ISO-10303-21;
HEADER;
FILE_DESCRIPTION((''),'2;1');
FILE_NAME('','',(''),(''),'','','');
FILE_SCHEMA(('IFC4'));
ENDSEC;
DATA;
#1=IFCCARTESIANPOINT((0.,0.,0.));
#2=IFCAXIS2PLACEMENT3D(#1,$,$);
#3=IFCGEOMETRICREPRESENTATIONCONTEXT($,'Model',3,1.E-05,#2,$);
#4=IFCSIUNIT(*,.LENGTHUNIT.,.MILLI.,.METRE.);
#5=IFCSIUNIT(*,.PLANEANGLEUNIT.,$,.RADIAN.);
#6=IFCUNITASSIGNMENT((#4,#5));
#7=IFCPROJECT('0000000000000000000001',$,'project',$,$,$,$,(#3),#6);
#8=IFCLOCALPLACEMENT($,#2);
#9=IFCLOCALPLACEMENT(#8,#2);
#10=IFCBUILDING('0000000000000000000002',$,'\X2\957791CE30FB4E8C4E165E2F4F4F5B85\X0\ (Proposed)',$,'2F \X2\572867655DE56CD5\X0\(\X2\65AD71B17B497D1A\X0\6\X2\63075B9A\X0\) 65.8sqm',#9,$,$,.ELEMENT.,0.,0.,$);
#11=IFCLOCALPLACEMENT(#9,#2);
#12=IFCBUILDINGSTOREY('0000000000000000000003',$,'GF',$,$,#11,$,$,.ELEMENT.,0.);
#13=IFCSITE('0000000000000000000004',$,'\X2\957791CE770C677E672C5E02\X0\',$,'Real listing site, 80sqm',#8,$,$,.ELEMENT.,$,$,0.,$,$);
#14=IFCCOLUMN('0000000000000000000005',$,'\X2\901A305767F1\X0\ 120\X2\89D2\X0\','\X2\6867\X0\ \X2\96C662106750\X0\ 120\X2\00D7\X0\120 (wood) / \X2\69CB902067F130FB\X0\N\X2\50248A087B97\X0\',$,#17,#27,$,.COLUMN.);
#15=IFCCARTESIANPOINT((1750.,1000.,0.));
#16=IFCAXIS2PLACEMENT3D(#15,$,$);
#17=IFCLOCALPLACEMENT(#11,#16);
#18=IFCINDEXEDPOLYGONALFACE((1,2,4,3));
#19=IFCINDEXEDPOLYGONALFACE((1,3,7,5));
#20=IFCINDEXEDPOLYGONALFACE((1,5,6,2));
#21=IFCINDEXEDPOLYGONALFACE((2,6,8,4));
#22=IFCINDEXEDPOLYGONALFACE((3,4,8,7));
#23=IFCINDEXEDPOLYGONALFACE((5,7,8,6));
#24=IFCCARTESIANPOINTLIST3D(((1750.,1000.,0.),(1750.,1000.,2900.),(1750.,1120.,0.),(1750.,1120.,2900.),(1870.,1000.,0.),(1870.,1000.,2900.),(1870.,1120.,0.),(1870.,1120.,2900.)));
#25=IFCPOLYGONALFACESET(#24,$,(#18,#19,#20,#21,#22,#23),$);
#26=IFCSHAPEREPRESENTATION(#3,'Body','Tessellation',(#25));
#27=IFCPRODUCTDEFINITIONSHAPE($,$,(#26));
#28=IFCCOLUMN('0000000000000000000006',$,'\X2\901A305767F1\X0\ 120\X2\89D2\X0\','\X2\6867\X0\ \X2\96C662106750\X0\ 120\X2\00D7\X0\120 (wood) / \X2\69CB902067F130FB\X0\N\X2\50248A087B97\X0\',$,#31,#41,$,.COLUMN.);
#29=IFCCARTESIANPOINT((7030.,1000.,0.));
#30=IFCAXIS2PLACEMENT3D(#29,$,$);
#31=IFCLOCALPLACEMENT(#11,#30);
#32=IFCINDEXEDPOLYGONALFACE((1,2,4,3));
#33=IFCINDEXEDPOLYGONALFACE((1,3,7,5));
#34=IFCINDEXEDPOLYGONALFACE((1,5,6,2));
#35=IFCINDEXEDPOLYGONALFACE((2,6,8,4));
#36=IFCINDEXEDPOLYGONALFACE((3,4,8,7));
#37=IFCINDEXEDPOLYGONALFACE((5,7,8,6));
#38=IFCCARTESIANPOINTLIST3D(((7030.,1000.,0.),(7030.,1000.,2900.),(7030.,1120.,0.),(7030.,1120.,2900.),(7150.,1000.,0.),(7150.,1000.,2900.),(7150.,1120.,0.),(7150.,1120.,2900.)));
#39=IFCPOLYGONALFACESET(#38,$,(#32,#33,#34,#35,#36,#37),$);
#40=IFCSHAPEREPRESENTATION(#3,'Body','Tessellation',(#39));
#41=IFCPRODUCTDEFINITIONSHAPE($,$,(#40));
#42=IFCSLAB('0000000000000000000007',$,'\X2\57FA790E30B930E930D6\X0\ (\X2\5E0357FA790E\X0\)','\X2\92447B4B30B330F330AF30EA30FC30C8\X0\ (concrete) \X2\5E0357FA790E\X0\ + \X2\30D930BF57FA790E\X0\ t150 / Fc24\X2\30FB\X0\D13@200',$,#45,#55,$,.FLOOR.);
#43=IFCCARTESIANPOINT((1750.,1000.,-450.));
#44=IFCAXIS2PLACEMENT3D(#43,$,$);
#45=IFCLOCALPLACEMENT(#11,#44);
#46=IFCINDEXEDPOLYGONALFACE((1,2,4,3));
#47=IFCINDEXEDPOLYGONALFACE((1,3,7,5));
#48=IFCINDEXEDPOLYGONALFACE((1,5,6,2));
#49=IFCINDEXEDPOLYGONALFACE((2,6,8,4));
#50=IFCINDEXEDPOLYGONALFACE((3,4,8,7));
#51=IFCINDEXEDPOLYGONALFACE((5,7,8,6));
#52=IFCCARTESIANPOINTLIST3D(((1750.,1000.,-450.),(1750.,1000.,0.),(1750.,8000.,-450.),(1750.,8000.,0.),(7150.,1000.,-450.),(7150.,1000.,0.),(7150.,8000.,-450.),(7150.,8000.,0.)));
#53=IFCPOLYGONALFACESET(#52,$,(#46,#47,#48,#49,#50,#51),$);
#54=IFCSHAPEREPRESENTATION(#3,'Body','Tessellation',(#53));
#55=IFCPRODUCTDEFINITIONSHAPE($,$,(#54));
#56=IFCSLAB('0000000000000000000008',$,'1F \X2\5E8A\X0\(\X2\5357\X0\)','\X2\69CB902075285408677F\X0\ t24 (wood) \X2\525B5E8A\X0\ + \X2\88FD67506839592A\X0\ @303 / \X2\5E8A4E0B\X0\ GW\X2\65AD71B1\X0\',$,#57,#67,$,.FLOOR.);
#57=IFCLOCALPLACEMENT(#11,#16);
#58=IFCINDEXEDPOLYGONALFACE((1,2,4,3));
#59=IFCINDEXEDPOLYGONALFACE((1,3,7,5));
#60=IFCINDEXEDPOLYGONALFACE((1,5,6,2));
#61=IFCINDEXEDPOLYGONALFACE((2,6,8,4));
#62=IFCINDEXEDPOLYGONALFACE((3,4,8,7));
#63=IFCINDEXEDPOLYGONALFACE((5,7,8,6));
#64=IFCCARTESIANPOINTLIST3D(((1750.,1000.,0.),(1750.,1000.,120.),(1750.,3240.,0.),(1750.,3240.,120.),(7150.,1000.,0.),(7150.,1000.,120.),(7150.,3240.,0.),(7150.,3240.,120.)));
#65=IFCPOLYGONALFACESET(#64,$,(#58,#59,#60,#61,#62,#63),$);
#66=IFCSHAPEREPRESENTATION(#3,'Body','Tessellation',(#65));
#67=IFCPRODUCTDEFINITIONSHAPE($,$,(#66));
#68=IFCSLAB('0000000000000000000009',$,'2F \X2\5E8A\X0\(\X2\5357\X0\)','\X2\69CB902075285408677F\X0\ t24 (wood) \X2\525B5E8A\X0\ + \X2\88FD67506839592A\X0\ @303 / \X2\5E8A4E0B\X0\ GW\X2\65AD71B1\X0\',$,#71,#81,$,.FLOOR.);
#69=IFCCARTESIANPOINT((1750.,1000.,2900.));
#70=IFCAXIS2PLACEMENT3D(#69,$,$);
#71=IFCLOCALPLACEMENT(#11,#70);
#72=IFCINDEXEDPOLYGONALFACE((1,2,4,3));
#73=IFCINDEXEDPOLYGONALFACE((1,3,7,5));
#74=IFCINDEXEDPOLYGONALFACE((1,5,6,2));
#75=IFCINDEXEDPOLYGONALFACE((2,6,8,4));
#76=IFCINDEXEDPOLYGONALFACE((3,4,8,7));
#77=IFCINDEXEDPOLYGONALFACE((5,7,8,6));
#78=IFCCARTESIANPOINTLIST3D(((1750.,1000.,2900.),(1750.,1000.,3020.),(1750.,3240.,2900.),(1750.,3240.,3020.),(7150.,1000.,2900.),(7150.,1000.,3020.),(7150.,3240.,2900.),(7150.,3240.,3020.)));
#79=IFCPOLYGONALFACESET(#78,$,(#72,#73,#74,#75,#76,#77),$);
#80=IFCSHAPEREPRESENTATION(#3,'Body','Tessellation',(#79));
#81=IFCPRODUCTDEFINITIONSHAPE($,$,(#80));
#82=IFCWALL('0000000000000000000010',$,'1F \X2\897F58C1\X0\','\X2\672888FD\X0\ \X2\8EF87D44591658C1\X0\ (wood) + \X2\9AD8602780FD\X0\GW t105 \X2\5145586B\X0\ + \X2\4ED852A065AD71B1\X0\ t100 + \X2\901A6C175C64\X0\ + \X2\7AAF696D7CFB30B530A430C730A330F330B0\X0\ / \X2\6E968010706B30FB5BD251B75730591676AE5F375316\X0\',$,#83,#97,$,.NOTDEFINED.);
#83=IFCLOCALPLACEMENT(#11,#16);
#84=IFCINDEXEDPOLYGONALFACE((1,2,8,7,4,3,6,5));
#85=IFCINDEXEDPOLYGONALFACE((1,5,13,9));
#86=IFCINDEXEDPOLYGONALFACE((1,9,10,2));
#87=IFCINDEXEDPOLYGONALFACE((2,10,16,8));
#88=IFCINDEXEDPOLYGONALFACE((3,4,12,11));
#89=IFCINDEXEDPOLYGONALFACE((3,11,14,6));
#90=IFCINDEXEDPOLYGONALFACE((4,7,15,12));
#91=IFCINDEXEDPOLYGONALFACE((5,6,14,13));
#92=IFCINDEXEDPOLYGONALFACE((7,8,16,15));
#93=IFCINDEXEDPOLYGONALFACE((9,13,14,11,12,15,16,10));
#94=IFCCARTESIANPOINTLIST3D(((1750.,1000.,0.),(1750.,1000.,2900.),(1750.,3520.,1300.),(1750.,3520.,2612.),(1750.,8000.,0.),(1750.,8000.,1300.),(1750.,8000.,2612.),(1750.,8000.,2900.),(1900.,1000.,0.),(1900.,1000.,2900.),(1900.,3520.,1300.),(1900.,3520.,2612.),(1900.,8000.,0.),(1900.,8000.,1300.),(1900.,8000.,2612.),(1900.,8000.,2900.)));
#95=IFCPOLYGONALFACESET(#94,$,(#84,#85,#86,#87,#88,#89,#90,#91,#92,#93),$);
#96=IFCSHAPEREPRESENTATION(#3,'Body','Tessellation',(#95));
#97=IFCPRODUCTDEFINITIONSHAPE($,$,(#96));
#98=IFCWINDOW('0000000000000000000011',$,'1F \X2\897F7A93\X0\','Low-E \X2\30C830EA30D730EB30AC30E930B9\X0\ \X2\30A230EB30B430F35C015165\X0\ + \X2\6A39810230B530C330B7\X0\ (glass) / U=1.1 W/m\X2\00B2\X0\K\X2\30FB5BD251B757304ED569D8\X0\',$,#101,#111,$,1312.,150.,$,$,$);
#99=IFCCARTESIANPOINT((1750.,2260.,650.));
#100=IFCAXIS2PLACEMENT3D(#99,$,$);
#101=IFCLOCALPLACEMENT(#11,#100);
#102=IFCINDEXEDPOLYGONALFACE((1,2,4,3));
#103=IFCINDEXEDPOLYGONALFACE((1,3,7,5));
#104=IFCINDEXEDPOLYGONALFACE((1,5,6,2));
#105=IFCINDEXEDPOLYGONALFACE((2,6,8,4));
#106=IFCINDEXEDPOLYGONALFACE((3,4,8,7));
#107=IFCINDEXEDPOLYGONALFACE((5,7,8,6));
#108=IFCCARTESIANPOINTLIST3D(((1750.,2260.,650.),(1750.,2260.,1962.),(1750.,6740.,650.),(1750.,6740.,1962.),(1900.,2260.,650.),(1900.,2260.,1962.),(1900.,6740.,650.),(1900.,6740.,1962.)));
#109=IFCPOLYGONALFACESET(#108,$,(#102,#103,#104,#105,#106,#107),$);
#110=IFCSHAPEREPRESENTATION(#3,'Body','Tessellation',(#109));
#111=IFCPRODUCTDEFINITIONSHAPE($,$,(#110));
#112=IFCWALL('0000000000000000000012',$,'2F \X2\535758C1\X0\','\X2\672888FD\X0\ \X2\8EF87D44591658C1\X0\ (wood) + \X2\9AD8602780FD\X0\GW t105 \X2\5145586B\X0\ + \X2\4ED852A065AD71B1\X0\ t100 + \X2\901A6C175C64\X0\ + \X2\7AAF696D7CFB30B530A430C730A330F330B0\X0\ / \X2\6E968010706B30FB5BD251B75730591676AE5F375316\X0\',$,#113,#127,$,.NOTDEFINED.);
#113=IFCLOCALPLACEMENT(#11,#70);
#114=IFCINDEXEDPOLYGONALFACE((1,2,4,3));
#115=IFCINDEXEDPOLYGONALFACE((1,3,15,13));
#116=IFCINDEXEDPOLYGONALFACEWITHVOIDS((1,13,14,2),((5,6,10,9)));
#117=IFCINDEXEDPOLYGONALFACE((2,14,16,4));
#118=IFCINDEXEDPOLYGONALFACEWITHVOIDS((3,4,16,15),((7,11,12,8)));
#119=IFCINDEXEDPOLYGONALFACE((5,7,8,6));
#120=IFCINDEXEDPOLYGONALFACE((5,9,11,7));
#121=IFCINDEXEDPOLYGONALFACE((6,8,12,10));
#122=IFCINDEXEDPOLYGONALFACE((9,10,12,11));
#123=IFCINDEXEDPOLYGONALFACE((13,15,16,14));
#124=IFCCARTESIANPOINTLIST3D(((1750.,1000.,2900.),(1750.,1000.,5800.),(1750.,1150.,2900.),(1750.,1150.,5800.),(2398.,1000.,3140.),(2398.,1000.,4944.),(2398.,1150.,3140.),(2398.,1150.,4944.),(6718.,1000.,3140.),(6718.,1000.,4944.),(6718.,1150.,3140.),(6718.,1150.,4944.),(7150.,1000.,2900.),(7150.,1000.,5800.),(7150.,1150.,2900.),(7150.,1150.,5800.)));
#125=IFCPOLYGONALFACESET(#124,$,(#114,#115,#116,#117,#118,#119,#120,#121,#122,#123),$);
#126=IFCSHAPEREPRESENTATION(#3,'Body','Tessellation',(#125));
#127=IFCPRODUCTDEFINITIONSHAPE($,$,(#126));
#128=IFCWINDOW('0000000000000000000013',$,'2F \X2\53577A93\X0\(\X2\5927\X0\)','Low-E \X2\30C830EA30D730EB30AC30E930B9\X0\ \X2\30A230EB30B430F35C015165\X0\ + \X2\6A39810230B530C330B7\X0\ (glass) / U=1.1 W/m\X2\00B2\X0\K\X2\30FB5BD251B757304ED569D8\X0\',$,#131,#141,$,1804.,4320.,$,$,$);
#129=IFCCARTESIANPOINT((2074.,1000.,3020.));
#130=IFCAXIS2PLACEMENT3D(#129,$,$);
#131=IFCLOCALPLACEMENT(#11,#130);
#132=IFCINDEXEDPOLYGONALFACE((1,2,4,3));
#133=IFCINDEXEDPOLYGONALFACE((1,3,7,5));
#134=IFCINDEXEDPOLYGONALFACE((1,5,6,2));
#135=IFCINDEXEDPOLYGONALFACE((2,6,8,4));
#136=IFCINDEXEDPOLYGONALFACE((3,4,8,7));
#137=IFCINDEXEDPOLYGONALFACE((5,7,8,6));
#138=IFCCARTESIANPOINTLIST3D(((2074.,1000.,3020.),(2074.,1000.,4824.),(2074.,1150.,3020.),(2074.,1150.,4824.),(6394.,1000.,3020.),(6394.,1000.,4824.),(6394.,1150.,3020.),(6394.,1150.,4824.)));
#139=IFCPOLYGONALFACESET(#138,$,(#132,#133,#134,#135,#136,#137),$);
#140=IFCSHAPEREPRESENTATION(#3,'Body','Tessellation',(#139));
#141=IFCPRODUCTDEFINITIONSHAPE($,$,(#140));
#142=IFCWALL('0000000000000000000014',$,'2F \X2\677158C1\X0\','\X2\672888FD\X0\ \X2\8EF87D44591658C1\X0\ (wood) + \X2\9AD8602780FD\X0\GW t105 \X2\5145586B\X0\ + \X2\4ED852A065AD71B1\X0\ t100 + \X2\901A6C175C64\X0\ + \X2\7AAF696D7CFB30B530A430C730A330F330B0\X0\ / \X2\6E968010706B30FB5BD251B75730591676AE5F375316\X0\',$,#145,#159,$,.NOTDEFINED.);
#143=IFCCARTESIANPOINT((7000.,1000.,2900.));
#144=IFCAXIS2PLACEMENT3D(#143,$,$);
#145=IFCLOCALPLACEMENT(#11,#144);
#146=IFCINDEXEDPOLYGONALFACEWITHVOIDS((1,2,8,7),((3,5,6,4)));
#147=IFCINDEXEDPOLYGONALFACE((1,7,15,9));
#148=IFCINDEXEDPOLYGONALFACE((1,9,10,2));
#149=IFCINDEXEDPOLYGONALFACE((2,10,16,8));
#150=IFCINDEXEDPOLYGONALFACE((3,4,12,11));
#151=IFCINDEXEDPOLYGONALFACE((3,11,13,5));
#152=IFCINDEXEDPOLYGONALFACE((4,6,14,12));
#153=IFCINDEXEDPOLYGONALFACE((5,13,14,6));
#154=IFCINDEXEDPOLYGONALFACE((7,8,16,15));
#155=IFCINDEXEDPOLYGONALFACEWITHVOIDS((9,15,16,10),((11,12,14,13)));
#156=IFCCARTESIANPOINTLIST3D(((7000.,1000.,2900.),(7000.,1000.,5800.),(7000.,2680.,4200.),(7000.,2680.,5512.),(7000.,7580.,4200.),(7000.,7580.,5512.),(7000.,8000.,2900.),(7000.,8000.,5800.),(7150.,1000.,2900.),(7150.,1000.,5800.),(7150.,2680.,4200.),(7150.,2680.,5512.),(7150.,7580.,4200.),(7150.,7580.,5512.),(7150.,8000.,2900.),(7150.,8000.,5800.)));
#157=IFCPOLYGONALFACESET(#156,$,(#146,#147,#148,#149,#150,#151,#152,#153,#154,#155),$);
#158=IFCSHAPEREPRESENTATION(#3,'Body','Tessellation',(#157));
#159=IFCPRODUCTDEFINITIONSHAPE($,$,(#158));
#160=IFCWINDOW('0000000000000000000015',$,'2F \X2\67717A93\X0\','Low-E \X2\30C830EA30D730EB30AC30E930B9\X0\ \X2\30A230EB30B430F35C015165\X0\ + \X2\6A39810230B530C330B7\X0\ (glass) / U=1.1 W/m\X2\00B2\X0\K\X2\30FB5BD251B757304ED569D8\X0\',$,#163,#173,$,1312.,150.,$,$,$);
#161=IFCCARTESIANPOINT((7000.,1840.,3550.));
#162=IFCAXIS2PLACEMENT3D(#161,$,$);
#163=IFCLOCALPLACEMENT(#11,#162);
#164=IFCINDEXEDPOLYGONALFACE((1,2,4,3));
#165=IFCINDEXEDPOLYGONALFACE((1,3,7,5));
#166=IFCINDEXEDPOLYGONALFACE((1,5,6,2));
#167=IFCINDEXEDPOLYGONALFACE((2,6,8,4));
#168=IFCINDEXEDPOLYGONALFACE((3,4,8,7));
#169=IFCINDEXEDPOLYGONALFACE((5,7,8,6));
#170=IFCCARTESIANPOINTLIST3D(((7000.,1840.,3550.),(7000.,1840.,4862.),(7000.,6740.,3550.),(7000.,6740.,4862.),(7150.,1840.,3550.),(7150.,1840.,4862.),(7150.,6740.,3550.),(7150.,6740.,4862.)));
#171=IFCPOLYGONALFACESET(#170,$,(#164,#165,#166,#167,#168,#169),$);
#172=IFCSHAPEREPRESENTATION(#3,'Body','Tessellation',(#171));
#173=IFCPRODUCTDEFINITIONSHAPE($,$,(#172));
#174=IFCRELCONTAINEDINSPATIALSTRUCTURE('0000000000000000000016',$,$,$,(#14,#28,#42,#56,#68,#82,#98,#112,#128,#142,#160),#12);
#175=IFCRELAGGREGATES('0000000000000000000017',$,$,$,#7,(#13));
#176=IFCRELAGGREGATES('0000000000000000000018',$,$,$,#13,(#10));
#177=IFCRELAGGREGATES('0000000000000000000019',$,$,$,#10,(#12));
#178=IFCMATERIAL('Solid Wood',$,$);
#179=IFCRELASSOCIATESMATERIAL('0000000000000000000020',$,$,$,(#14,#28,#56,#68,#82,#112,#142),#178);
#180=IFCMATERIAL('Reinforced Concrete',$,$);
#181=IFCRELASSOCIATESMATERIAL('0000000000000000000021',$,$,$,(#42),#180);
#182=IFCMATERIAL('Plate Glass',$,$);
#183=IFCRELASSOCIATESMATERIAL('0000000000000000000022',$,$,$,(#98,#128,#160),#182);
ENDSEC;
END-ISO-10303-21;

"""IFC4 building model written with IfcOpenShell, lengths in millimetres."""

from ifc_helpers import new_model, si_unit, frame, frame_2d, origin, place, context, project, spatial, rectangle, extrude, material, element, fill, save


model = new_model("IFC4")

# Units and contexts
model_context = context("Model", 3, precision=1e-05, world=origin())
ifc_project = project(units=[si_unit("LENGTHUNIT", "METRE", prefix="MILLI"), si_unit("PLANEANGLEUNIT", "RADIAN")], contexts=[model_context])

# Site, building, storey
site_placement = place(None, origin())
site = spatial("IfcSite", under=ifc_project, at=site_placement, Name="長野県松本市", ObjectType="Real listing site, 80sqm", CompositionType="ELEMENT", RefElevation=0.0)
building_placement = place(site_placement, origin())
building = spatial("IfcBuilding", under=site, at=building_placement, Name="長野・二世帯住宅 (Proposed)", ObjectType="2F 在来工法(断熱等級6指定) 65.8sqm", CompositionType="ELEMENT", ElevationOfRefHeight=0.0, ElevationOfTerrain=0.0)
storey_placement = place(building_placement, origin())
storey = spatial("IfcBuildingStorey", under=building, at=storey_placement, Name="GF", CompositionType="ELEMENT", Elevation=0.0)

# Columns
ifc_material_1 = material(Name="Solid Wood")
column_1_placement = place(storey_placement, frame((1750.0, 1000.0, 0.0)))
element("IfcColumn", 1, at=column_1_placement, inside=storey, material=ifc_material_1, Name="通し柱 120角", Description="桧 集成材 120×120 (wood) / 構造柱・N値計算", PredefinedType="COLUMN", context=model_context, shape_type="SweptSolid", body=[
    extrude(rectangle(XDim=120.0, YDim=120.0, at=frame_2d((60.0, 60.0))), frame((1750.0, 1000.0, 0.0)), (0.0, 0.0, 1.0), 2900.0),
])
column_2_placement = place(storey_placement, frame((7030.0, 1000.0, 0.0)))
element("IfcColumn", 2, at=column_2_placement, inside=storey, material=ifc_material_1, Name="通し柱 120角", Description="桧 集成材 120×120 (wood) / 構造柱・N値計算", PredefinedType="COLUMN", context=model_context, shape_type="SweptSolid", body=[
    extrude(rectangle(XDim=120.0, YDim=120.0, at=frame_2d((60.0, 60.0))), frame((7030.0, 1000.0, 0.0)), (0.0, 0.0, 1.0), 2900.0),
])

# Slabs
ifc_material_2 = material(Name="Reinforced Concrete")
slab_1_placement = place(storey_placement, frame((1750.0, 1000.0, -450.0)))
element("IfcSlab", 3, at=slab_1_placement, inside=storey, material=ifc_material_2, Name="基礎スラブ (布基礎)", Description="鉄筋コンクリート (concrete) 布基礎 + ベタ基礎 t150 / Fc24・D13@200", PredefinedType="FLOOR", context=model_context, shape_type="SweptSolid", body=[
    extrude(rectangle(XDim=5400.0, YDim=7000.0, at=frame_2d((2700.0, 3500.0))), frame((1750.0, 1000.0, -450.0)), (0.0, 0.0, 1.0), 450.0),
])
slab_2_placement = place(storey_placement, frame((1750.0, 1000.0, 0.0)))
element("IfcSlab", 4, at=slab_2_placement, inside=storey, material=ifc_material_1, Name="1F 床(南)", Description="構造用合板 t24 (wood) 剛床 + 製材根太 @303 / 床下 GW断熱", PredefinedType="FLOOR", context=model_context, shape_type="SweptSolid", body=[
    extrude(rectangle(XDim=5400.0, YDim=2240.0, at=frame_2d((2700.0, 1120.0))), frame((1750.0, 1000.0, 0.0)), (0.0, 0.0, 1.0), 120.0),
])
slab_3_placement = place(storey_placement, frame((1750.0, 1000.0, 2900.0)))
element("IfcSlab", 5, at=slab_3_placement, inside=storey, material=ifc_material_1, Name="2F 床(南)", Description="構造用合板 t24 (wood) 剛床 + 製材根太 @303 / 床下 GW断熱", PredefinedType="FLOOR", context=model_context, shape_type="SweptSolid", body=[
    extrude(rectangle(XDim=5400.0, YDim=2240.0, at=frame_2d((2700.0, 1120.0))), frame((1750.0, 1000.0, 2900.0)), (0.0, 0.0, 1.0), 120.0),
])

# Shared definitions
ifc_material_3 = material(Name="Plate Glass")

# Walls, openings, windows
wall_1_placement = place(storey_placement, frame((1750.0, 1000.0, 0.0)))
wall_1 = element("IfcWall", 6, at=wall_1_placement, inside=storey, material=ifc_material_1, Name="1F 西壁", Description="木製 軸組外壁 (wood) + 高性能GW t105 充填 + 付加断熱 t100 + 通気層 + 窯業系サイディング / 準耐火・寒冷地外皮強化", PredefinedType="NOTDEFINED", context=model_context, shape_type="SweptSolid", body=[
    extrude(rectangle(XDim=150.0, YDim=7000.0, at=frame_2d((75.0, 3500.0))), frame((1750.0, 1000.0, 0.0)), (0.0, 0.0, 1.0), 2900.0),
])
opening_1_placement = place(storey_placement, frame((1750.0, 2260.0, 650.0)))
opening_1 = element("IfcOpeningElement", 7, at=opening_1_placement, cuts=wall_1, PredefinedType="NOTDEFINED", context=model_context, shape_type="SweptSolid", body=[
    extrude(rectangle(XDim=150.0, YDim=4480.0, at=frame_2d((75.0, 2240.0))), frame((1750.0, 2260.0, 650.0)), (0.0, 0.0, 1.0), 1312.0),
])
window_1_placement = place(storey_placement, frame((1750.0, 2260.0, 650.0)))
window_1 = element("IfcWindow", 8, at=window_1_placement, inside=storey, material=ifc_material_3, Name="1F 西窓", Description="Low-E トリプルガラス アルゴン封入 + 樹脂サッシ (glass) / U=1.1 W/m²K・寒冷地仕様", OverallHeight=1312.0, OverallWidth=150.0, context=model_context, shape_type="SweptSolid", body=[
    extrude(rectangle(XDim=150.0, YDim=4480.0, at=frame_2d((75.0, 2240.0))), frame((1750.0, 2260.0, 650.0)), (0.0, 0.0, 1.0), 1312.0),
])
fill(opening_1, window_1)
wall_2_placement = place(storey_placement, frame((1750.0, 1000.0, 2900.0)))
wall_2 = element("IfcWall", 9, at=wall_2_placement, inside=storey, material=ifc_material_1, Name="2F 南壁", Description="木製 軸組外壁 (wood) + 高性能GW t105 充填 + 付加断熱 t100 + 通気層 + 窯業系サイディング / 準耐火・寒冷地外皮強化", PredefinedType="NOTDEFINED", context=model_context, shape_type="SweptSolid", body=[
    extrude(rectangle(XDim=5400.0, YDim=150.0, at=frame_2d((2700.0, 75.0))), frame((1750.0, 1000.0, 2900.0)), (0.0, 0.0, 1.0), 2900.0),
])
opening_2_placement = place(storey_placement, frame((2074.0, 1000.0, 3020.0)))
opening_2 = element("IfcOpeningElement", 10, at=opening_2_placement, cuts=wall_2, PredefinedType="NOTDEFINED", context=model_context, shape_type="SweptSolid", body=[
    extrude(rectangle(XDim=4320.0, YDim=150.0, at=frame_2d((2160.0, 75.0))), frame((2074.0, 1000.0, 3020.0)), (0.0, 0.0, 1.0), 1804.0),
])
window_2_placement = place(storey_placement, frame((2074.0, 1000.0, 3020.0)))
window_2 = element("IfcWindow", 11, at=window_2_placement, inside=storey, material=ifc_material_3, Name="2F 南窓(大)", Description="Low-E トリプルガラス アルゴン封入 + 樹脂サッシ (glass) / U=1.1 W/m²K・寒冷地仕様", OverallHeight=1804.0, OverallWidth=4320.0, context=model_context, shape_type="SweptSolid", body=[
    extrude(rectangle(XDim=4320.0, YDim=150.0, at=frame_2d((2160.0, 75.0))), frame((2074.0, 1000.0, 3020.0)), (0.0, 0.0, 1.0), 1804.0),
])
fill(opening_2, window_2)
wall_3_placement = place(storey_placement, frame((7000.0, 1000.0, 2900.0)))
wall_3 = element("IfcWall", 12, at=wall_3_placement, inside=storey, material=ifc_material_1, Name="2F 東壁", Description="木製 軸組外壁 (wood) + 高性能GW t105 充填 + 付加断熱 t100 + 通気層 + 窯業系サイディング / 準耐火・寒冷地外皮強化", PredefinedType="NOTDEFINED", context=model_context, shape_type="SweptSolid", body=[
    extrude(rectangle(XDim=150.0, YDim=7000.0, at=frame_2d((75.0, 3500.0))), frame((7000.0, 1000.0, 2900.0)), (0.0, 0.0, 1.0), 2900.0),
])
opening_3_placement = place(storey_placement, frame((7000.0, 1840.0, 3550.0)))
opening_3 = element("IfcOpeningElement", 13, at=opening_3_placement, cuts=wall_3, PredefinedType="NOTDEFINED", context=model_context, shape_type="SweptSolid", body=[
    extrude(rectangle(XDim=150.0, YDim=4900.0, at=frame_2d((75.0, 2450.0))), frame((7000.0, 1840.0, 3550.0)), (0.0, 0.0, 1.0), 1312.0),
])
window_3_placement = place(storey_placement, frame((7000.0, 1840.0, 3550.0)))
window_3 = element("IfcWindow", 14, at=window_3_placement, inside=storey, material=ifc_material_3, Name="2F 東窓", Description="Low-E トリプルガラス アルゴン封入 + 樹脂サッシ (glass) / U=1.1 W/m²K・寒冷地仕様", OverallHeight=1312.0, OverallWidth=150.0, context=model_context, shape_type="SweptSolid", body=[
    extrude(rectangle(XDim=150.0, YDim=4900.0, at=frame_2d((75.0, 2450.0))), frame((7000.0, 1840.0, 3550.0)), (0.0, 0.0, 1.0), 1312.0),
])
fill(opening_3, window_3)

save(model, "model.ifc")
